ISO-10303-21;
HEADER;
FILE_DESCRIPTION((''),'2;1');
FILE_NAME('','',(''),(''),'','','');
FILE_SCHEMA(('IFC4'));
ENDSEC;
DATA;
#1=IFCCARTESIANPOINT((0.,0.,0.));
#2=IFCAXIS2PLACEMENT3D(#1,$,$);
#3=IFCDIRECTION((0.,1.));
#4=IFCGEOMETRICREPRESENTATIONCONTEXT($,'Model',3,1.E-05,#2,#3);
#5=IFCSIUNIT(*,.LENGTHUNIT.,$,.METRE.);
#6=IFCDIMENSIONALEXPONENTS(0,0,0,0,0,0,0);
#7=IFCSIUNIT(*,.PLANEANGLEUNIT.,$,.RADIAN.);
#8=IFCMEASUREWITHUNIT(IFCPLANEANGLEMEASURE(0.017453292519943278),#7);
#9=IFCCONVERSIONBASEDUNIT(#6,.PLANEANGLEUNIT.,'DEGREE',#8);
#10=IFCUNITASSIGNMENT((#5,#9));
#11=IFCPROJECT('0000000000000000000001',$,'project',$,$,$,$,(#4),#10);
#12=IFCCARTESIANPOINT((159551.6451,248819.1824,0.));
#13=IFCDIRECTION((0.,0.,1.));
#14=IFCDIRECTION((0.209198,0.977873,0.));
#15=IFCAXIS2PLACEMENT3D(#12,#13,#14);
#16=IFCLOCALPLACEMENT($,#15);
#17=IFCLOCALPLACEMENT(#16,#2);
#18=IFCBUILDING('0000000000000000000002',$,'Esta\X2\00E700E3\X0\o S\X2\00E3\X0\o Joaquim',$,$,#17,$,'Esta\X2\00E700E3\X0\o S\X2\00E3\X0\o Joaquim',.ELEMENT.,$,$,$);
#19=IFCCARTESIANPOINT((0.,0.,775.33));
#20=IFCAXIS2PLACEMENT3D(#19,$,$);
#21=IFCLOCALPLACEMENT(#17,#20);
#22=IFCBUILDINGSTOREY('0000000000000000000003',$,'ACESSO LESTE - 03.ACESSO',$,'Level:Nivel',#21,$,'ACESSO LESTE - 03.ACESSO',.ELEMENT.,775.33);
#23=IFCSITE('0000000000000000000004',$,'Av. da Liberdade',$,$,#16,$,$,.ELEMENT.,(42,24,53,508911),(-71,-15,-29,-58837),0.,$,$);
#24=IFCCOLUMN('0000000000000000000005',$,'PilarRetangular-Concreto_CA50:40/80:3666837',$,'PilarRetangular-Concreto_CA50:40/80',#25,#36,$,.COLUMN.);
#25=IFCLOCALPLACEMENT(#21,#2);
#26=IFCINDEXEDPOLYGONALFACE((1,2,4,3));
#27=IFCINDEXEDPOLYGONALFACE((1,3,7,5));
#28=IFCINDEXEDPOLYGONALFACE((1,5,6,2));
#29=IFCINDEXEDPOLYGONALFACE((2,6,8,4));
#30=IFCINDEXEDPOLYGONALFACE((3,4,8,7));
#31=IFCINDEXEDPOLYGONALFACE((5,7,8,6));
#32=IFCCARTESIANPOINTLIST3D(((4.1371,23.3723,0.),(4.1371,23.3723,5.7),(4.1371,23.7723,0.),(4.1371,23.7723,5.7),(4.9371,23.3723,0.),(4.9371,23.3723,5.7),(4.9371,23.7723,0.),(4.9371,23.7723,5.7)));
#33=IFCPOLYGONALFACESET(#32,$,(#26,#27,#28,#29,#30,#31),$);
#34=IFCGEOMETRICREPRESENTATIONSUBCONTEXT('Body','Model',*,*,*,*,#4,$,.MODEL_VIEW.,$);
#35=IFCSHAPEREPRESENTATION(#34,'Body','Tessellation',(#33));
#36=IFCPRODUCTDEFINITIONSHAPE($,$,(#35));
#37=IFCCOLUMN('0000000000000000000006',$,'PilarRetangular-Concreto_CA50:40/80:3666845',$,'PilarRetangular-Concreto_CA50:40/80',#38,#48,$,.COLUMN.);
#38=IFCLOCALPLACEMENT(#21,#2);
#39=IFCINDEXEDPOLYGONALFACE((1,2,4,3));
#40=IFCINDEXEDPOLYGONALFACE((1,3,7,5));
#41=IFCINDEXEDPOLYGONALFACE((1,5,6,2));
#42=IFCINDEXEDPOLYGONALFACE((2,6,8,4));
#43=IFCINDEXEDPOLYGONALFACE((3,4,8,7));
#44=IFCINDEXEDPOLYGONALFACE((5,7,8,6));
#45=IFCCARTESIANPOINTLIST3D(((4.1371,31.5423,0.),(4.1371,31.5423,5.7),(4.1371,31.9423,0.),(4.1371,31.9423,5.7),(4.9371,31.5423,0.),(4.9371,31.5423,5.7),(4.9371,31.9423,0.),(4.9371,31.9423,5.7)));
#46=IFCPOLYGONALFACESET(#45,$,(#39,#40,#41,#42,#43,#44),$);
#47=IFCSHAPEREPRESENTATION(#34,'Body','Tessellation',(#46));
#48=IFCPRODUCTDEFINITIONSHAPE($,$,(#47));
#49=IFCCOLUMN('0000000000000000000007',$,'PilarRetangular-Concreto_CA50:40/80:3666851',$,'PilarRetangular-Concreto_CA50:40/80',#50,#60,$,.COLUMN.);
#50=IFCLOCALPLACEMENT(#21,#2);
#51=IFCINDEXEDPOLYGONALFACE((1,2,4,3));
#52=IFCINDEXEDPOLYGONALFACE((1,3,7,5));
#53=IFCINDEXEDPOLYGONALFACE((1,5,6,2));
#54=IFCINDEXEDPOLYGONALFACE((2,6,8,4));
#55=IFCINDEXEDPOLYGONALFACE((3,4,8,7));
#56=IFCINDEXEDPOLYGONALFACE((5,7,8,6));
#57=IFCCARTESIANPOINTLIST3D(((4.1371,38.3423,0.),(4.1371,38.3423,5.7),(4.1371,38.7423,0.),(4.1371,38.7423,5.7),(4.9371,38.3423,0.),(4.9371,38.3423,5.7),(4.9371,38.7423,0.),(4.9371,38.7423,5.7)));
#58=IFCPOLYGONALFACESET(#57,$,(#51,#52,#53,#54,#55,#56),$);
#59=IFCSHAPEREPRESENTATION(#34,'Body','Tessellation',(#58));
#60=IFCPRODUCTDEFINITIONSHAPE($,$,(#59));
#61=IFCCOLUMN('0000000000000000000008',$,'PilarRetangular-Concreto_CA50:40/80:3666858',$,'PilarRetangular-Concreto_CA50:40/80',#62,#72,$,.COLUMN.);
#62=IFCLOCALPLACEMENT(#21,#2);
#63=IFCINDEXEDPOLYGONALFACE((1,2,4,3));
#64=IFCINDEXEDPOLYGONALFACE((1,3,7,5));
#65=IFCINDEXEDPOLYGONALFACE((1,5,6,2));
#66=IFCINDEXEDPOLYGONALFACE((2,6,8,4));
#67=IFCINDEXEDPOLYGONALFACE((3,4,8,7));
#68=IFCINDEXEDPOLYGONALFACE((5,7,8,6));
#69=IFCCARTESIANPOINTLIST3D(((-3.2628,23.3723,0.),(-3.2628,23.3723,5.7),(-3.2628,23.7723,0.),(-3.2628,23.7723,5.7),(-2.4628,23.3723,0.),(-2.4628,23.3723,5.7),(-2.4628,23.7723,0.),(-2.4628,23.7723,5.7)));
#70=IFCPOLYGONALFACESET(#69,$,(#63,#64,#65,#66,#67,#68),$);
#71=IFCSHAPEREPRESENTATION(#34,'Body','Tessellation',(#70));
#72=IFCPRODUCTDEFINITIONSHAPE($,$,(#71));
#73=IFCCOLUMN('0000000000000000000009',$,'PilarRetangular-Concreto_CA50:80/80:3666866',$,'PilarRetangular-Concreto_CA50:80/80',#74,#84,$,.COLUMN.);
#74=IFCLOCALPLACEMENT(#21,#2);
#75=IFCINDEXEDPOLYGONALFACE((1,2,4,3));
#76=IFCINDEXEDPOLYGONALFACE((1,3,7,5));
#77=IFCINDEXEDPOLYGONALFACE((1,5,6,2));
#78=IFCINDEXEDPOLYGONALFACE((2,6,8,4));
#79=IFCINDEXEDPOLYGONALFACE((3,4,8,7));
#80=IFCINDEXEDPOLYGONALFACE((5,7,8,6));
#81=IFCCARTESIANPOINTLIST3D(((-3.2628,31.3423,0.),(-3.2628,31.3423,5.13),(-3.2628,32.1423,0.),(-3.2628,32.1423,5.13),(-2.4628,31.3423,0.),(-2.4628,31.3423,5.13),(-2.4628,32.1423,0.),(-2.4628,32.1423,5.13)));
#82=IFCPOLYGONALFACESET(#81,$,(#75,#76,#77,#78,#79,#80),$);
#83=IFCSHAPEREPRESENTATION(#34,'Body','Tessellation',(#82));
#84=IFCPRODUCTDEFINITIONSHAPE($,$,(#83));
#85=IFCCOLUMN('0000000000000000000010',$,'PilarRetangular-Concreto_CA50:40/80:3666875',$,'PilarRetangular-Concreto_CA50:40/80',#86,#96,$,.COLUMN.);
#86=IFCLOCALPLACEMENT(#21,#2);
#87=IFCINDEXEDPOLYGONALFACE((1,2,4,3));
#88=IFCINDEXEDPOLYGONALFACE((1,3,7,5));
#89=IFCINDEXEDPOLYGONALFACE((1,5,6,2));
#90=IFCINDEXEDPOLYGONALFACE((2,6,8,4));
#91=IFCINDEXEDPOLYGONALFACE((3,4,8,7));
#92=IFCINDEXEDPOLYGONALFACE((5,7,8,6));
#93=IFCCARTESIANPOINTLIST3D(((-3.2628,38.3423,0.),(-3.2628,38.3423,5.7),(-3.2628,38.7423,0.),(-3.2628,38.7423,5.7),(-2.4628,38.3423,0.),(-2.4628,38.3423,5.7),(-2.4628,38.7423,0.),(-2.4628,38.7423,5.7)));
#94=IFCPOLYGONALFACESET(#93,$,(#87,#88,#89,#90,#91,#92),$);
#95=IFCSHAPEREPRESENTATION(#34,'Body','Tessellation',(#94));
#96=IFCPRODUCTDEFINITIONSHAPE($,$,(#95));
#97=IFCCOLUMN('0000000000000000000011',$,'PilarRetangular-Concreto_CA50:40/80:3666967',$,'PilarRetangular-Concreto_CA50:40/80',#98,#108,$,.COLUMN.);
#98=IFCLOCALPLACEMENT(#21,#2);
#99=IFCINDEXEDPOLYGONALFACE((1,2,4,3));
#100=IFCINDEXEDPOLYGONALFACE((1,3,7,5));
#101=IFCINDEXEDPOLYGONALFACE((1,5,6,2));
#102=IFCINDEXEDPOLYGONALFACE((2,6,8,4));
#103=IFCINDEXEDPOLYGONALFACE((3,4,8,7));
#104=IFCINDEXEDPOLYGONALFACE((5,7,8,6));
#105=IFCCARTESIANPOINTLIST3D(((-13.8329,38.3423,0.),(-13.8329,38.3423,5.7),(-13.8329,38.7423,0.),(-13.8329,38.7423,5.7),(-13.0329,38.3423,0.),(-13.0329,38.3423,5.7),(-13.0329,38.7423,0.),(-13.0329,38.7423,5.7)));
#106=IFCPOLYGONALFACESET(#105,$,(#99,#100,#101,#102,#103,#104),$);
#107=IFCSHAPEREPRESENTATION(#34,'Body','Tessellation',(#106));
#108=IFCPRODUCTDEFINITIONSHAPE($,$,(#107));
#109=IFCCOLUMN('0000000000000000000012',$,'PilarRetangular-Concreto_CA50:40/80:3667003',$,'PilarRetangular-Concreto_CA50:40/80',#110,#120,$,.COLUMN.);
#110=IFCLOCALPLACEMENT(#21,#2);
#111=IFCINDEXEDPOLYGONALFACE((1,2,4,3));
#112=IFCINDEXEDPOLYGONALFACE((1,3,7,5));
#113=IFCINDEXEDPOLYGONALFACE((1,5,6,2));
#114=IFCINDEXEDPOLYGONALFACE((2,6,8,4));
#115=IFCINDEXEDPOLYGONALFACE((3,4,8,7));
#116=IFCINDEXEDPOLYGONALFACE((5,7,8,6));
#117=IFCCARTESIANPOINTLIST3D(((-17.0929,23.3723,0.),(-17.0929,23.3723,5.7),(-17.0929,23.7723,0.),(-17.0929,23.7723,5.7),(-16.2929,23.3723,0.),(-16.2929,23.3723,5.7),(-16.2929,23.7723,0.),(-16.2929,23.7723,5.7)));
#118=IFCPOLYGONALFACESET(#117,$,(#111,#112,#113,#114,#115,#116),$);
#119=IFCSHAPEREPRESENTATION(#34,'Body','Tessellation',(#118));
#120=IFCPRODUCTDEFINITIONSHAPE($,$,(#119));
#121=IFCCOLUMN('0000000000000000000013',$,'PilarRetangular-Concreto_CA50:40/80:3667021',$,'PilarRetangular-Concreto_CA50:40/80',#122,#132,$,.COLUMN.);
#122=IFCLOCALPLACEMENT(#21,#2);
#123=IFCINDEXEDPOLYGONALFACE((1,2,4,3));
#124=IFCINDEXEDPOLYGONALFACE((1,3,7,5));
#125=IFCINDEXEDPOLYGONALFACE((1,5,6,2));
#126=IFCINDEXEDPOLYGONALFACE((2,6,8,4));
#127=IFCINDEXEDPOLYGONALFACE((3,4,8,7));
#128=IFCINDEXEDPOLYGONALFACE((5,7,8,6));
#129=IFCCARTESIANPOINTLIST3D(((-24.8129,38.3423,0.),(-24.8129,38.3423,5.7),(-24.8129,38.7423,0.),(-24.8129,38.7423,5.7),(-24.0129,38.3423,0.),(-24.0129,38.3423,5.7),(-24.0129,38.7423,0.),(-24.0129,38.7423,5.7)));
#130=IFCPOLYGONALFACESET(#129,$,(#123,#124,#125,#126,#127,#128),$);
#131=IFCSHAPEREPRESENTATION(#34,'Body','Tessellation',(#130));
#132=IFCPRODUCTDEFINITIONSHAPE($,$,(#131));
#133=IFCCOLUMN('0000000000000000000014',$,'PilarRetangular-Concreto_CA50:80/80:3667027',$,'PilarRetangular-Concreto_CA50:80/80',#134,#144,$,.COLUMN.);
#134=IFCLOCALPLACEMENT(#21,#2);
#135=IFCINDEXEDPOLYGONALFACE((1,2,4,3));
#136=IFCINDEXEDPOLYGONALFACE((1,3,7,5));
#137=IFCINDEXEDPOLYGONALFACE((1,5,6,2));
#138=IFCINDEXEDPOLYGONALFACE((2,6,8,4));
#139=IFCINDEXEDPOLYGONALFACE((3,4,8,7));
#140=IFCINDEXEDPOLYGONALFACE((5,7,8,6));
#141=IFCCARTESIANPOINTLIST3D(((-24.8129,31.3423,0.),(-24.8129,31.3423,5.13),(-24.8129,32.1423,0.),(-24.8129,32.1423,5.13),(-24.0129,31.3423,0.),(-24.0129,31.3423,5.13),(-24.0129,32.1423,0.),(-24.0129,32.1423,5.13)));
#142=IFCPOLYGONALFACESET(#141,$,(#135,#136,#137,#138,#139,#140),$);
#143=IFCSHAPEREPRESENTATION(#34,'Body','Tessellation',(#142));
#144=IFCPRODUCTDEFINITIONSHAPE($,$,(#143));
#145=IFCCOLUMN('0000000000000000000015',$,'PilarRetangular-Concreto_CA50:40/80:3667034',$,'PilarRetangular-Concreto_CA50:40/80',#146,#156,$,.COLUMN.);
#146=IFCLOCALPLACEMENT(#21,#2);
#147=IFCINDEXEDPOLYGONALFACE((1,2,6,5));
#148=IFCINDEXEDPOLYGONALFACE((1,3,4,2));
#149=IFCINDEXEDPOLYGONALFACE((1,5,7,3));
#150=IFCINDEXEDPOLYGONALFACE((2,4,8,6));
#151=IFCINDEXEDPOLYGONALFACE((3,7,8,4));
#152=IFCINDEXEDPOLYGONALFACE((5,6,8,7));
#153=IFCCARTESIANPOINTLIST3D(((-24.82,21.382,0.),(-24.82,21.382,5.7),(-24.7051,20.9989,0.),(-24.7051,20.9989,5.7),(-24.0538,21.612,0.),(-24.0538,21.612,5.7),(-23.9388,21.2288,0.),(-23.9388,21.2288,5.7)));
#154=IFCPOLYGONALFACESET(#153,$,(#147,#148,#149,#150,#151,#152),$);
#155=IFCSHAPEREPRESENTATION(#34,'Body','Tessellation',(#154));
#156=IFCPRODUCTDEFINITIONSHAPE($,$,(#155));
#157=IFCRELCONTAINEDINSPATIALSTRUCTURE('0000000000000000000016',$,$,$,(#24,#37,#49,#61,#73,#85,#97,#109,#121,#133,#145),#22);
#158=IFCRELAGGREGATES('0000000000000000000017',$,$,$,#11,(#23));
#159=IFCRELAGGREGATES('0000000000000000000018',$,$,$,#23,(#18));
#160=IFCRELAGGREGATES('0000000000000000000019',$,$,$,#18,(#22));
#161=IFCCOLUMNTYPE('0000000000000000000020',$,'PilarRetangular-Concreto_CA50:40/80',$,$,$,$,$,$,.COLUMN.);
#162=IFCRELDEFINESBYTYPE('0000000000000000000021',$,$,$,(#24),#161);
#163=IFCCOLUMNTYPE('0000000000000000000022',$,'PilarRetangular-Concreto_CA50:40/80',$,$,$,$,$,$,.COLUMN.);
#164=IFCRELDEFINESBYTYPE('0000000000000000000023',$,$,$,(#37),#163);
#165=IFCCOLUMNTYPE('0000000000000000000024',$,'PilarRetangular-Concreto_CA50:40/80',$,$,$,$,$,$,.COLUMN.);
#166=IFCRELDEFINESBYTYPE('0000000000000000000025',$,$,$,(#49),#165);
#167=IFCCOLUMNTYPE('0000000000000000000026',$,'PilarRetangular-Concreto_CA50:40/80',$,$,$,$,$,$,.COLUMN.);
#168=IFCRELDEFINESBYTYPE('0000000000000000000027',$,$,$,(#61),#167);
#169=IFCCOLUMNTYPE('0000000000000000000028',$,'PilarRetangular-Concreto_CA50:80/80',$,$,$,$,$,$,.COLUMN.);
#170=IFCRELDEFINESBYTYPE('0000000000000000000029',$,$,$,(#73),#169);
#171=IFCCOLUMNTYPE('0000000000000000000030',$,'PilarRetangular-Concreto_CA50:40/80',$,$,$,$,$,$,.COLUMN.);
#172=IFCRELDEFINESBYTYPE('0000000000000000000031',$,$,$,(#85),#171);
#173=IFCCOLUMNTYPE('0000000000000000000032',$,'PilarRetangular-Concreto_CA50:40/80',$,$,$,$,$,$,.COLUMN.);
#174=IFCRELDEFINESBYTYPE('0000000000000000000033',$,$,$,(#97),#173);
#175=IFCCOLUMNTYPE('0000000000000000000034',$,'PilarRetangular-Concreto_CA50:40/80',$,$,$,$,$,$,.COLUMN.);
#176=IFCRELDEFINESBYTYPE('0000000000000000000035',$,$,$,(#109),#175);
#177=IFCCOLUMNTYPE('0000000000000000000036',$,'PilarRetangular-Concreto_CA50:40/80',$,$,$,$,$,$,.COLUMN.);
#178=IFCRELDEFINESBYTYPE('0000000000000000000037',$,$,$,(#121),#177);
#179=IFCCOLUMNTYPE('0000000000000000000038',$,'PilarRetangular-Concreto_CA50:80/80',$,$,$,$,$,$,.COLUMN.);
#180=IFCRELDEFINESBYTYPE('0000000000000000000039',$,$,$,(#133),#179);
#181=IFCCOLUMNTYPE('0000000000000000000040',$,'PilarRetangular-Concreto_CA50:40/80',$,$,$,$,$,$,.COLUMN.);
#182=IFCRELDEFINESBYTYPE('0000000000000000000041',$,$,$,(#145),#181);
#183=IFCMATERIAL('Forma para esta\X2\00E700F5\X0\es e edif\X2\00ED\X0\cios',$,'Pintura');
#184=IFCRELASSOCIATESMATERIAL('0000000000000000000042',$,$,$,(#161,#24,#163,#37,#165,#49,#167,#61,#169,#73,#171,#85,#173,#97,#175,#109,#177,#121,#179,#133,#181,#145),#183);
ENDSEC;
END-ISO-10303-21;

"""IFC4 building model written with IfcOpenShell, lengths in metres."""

from ifc_helpers import new_model, entity, si_unit, converted_unit, direction, frame, origin, place, context, subcontext, project, spatial, indexed_curve, outline, extrude, source, transform, mapped, material, type_object, type_shapes, element, save


model = new_model("IFC4")

# Units and contexts
model_context = context("Model", 3, precision=1e-05, world=origin(), true_north=direction((0.0, 1.0)))
body_context = subcontext(model_context, "Body", "Model", "MODEL_VIEW")
ifc_project = project(units=[si_unit("LENGTHUNIT", "METRE"), converted_unit("PLANEANGLEUNIT", "DEGREE", entity("IfcPlaneAngleMeasure", 0.017453292519943278), si_unit("PLANEANGLEUNIT", "RADIAN"), dimensions=[0, 0, 0, 0, 0, 0, 0])], contexts=[model_context])

# Site, building, storey
site_placement = place(None, frame((159551.6451, 248819.1824, 0.0), z_axis=(0.0, 0.0, 1.0), x_axis=(0.209198, 0.977873, 0.0)))
site = spatial("IfcSite", under=ifc_project, at=site_placement, Name="Av. da Liberdade", CompositionType="ELEMENT", RefLatitude=(42, 24, 53, 508911), RefLongitude=(-71, -15, -29, -58837), RefElevation=0.0)
building_placement = place(site_placement, origin())
building = spatial("IfcBuilding", under=site, at=building_placement, Name="Estação São Joaquim", LongName="Estação São Joaquim", CompositionType="ELEMENT")
storey_placement = place(building_placement, frame((0.0, 0.0, 775.33)))
storey = spatial("IfcBuildingStorey", under=building, at=storey_placement, Name="ACESSO LESTE - 03.ACESSO", ObjectType="Level:Nivel", LongName="ACESSO LESTE - 03.ACESSO", CompositionType="ELEMENT", Elevation=775.33)

# Columns
ifc_material_1 = material(Name="Forma para estações e edifícios", Category="Pintura")
column_type_1 = type_object("IfcColumnType", Name="PilarRetangular-Concreto_CA50:40/80", PredefinedType="COLUMN", material=ifc_material_1)
shared_shape_1 = source(origin(), body_context, "Body", "SweptSolid", [
    extrude(outline(indexed_curve([(-0.2, -0.4), (0.2, -0.4), (0.2, 0.4), (-0.2, 0.4), (-0.2, -0.4)], self_intersect=False)), frame((4.5371, 23.5723, 775.33), z_axis=(0.0, 0.0, 1.0), x_axis=(0.0, -1.0, 0.0)), (0.0, 0.0, 1.0), 5.7),
])
type_shapes(column_type_1, [shared_shape_1])
column_1_placement = place(storey_placement, frame((0.0, 0.0, -775.33)))
element("IfcColumn", 1, at=column_1_placement, inside=storey, type_object=column_type_1, material=ifc_material_1, Name="PilarRetangular-Concreto_CA50:40/80:3666837", ObjectType="PilarRetangular-Concreto_CA50:40/80", PredefinedType="COLUMN", context=body_context, shape_type="MappedRepresentation", body=[
    mapped(shared_shape_1, transform((0.0, 0.0, 0.0), scale=1.0)),
])
column_type_2 = type_object("IfcColumnType", Name="PilarRetangular-Concreto_CA50:40/80", PredefinedType="COLUMN", material=ifc_material_1)
shared_shape_2 = source(origin(), body_context, "Body", "SweptSolid", [
    extrude(outline(indexed_curve([(-0.2, -0.4), (0.2, -0.4), (0.2, 0.4), (-0.2, 0.4), (-0.2, -0.4)], self_intersect=False)), frame((4.5371, 31.7423, 775.33), z_axis=(0.0, 0.0, 1.0), x_axis=(0.0, -1.0, 0.0)), (0.0, 0.0, 1.0), 5.7),
])
type_shapes(column_type_2, [shared_shape_2])
column_2_placement = place(storey_placement, frame((0.0, 0.0, -775.33)))
element("IfcColumn", 2, at=column_2_placement, inside=storey, type_object=column_type_2, material=ifc_material_1, Name="PilarRetangular-Concreto_CA50:40/80:3666845", ObjectType="PilarRetangular-Concreto_CA50:40/80", PredefinedType="COLUMN", context=body_context, shape_type="MappedRepresentation", body=[
    mapped(shared_shape_2, transform((0.0, 0.0, 0.0), scale=1.0)),
])
column_type_3 = type_object("IfcColumnType", Name="PilarRetangular-Concreto_CA50:40/80", PredefinedType="COLUMN", material=ifc_material_1)
shared_shape_3 = source(origin(), body_context, "Body", "SweptSolid", [
    extrude(outline(indexed_curve([(-0.2, -0.4), (0.2, -0.4), (0.2, 0.4), (-0.2, 0.4), (-0.2, -0.4)], self_intersect=False)), frame((4.5371, 38.5423, 775.33), z_axis=(0.0, 0.0, 1.0), x_axis=(0.0, 1.0, 0.0)), (0.0, 0.0, 1.0), 5.7),
])
type_shapes(column_type_3, [shared_shape_3])
column_3_placement = place(storey_placement, frame((0.0, 0.0, -775.33)))
element("IfcColumn", 3, at=column_3_placement, inside=storey, type_object=column_type_3, material=ifc_material_1, Name="PilarRetangular-Concreto_CA50:40/80:3666851", ObjectType="PilarRetangular-Concreto_CA50:40/80", PredefinedType="COLUMN", context=body_context, shape_type="MappedRepresentation", body=[
    mapped(shared_shape_3, transform((0.0, 0.0, 0.0), scale=1.0)),
])
column_type_4 = type_object("IfcColumnType", Name="PilarRetangular-Concreto_CA50:40/80", PredefinedType="COLUMN", material=ifc_material_1)
shared_shape_4 = source(origin(), body_context, "Body", "SweptSolid", [
    extrude(outline(indexed_curve([(-0.2, -0.4), (0.2, -0.4), (0.2, 0.4), (-0.2, 0.4), (-0.2, -0.4)], self_intersect=False)), frame((-2.8628, 23.5723, 775.33), z_axis=(0.0, 0.0, 1.0), x_axis=(0.0, -1.0, 0.0)), (0.0, 0.0, 1.0), 5.7),
])
type_shapes(column_type_4, [shared_shape_4])
column_4_placement = place(storey_placement, frame((0.0, 0.0, -775.33)))
element("IfcColumn", 4, at=column_4_placement, inside=storey, type_object=column_type_4, material=ifc_material_1, Name="PilarRetangular-Concreto_CA50:40/80:3666858", ObjectType="PilarRetangular-Concreto_CA50:40/80", PredefinedType="COLUMN", context=body_context, shape_type="MappedRepresentation", body=[
    mapped(shared_shape_4, transform((0.0, 0.0, 0.0), scale=1.0)),
])
column_type_5 = type_object("IfcColumnType", Name="PilarRetangular-Concreto_CA50:80/80", PredefinedType="COLUMN", material=ifc_material_1)
shared_shape_5 = source(origin(), body_context, "Body", "SweptSolid", [
    extrude(outline(indexed_curve([(-0.4, -0.4), (0.4, -0.4), (0.4, 0.4), (-0.4, 0.4), (-0.4, -0.4)], self_intersect=False)), frame((-2.8628, 31.7423, 775.33), z_axis=(0.0, 0.0, 1.0), x_axis=(-1.0, 0.0, 0.0)), (0.0, 0.0, 1.0), 5.13),
])
type_shapes(column_type_5, [shared_shape_5])
column_5_placement = place(storey_placement, frame((0.0, 0.0, -775.33)))
element("IfcColumn", 5, at=column_5_placement, inside=storey, type_object=column_type_5, material=ifc_material_1, Name="PilarRetangular-Concreto_CA50:80/80:3666866", ObjectType="PilarRetangular-Concreto_CA50:80/80", PredefinedType="COLUMN", context=body_context, shape_type="MappedRepresentation", body=[
    mapped(shared_shape_5, transform((0.0, 0.0, 0.0), scale=1.0)),
])
column_type_6 = type_object("IfcColumnType", Name="PilarRetangular-Concreto_CA50:40/80", PredefinedType="COLUMN", material=ifc_material_1)
shared_shape_6 = source(origin(), body_context, "Body", "SweptSolid", [
    extrude(outline(indexed_curve([(-0.2, -0.4), (0.2, -0.4), (0.2, 0.4), (-0.2, 0.4), (-0.2, -0.4)], self_intersect=False)), frame((-2.8628, 38.5423, 775.33), z_axis=(0.0, 0.0, 1.0), x_axis=(0.0, 1.0, 0.0)), (0.0, 0.0, 1.0), 5.7),
])
type_shapes(column_type_6, [shared_shape_6])
column_6_placement = place(storey_placement, frame((0.0, 0.0, -775.33)))
element("IfcColumn", 6, at=column_6_placement, inside=storey, type_object=column_type_6, material=ifc_material_1, Name="PilarRetangular-Concreto_CA50:40/80:3666875", ObjectType="PilarRetangular-Concreto_CA50:40/80", PredefinedType="COLUMN", context=body_context, shape_type="MappedRepresentation", body=[
    mapped(shared_shape_6, transform((0.0, 0.0, 0.0), scale=1.0)),
])
column_type_7 = type_object("IfcColumnType", Name="PilarRetangular-Concreto_CA50:40/80", PredefinedType="COLUMN", material=ifc_material_1)
shared_shape_7 = source(origin(), body_context, "Body", "SweptSolid", [
    extrude(outline(indexed_curve([(-0.2, -0.4), (0.2, -0.4), (0.2, 0.4), (-0.2, 0.4), (-0.2, -0.4)], self_intersect=False)), frame((-13.4329, 38.5423, 775.33), z_axis=(0.0, 0.0, 1.0), x_axis=(0.0, 1.0, 0.0)), (0.0, 0.0, 1.0), 5.7),
])
type_shapes(column_type_7, [shared_shape_7])
column_7_placement = place(storey_placement, frame((0.0, 0.0, -775.33)))
element("IfcColumn", 7, at=column_7_placement, inside=storey, type_object=column_type_7, material=ifc_material_1, Name="PilarRetangular-Concreto_CA50:40/80:3666967", ObjectType="PilarRetangular-Concreto_CA50:40/80", PredefinedType="COLUMN", context=body_context, shape_type="MappedRepresentation", body=[
    mapped(shared_shape_7, transform((0.0, 0.0, 0.0), scale=1.0)),
])
column_type_8 = type_object("IfcColumnType", Name="PilarRetangular-Concreto_CA50:40/80", PredefinedType="COLUMN", material=ifc_material_1)
shared_shape_8 = source(origin(), body_context, "Body", "SweptSolid", [
    extrude(outline(indexed_curve([(-0.2, -0.4), (0.2, -0.4), (0.2, 0.4), (-0.2, 0.4), (-0.2, -0.4)], self_intersect=False)), frame((-16.6929, 23.5723, 775.33), z_axis=(0.0, 0.0, 1.0), x_axis=(0.0, -1.0, 0.0)), (0.0, 0.0, 1.0), 5.7),
])
type_shapes(column_type_8, [shared_shape_8])
column_8_placement = place(storey_placement, frame((0.0, 0.0, -775.33)))
element("IfcColumn", 8, at=column_8_placement, inside=storey, type_object=column_type_8, material=ifc_material_1, Name="PilarRetangular-Concreto_CA50:40/80:3667003", ObjectType="PilarRetangular-Concreto_CA50:40/80", PredefinedType="COLUMN", context=body_context, shape_type="MappedRepresentation", body=[
    mapped(shared_shape_8, transform((0.0, 0.0, 0.0), scale=1.0)),
])
column_type_9 = type_object("IfcColumnType", Name="PilarRetangular-Concreto_CA50:40/80", PredefinedType="COLUMN", material=ifc_material_1)
shared_shape_9 = source(origin(), body_context, "Body", "SweptSolid", [
    extrude(outline(indexed_curve([(-0.2, -0.4), (0.2, -0.4), (0.2, 0.4), (-0.2, 0.4), (-0.2, -0.4)], self_intersect=False)), frame((-24.4129, 38.5423, 775.33), z_axis=(0.0, 0.0, 1.0), x_axis=(0.0, -1.0, 0.0)), (0.0, 0.0, 1.0), 5.7),
])
type_shapes(column_type_9, [shared_shape_9])
column_9_placement = place(storey_placement, frame((0.0, 0.0, -775.33)))
element("IfcColumn", 9, at=column_9_placement, inside=storey, type_object=column_type_9, material=ifc_material_1, Name="PilarRetangular-Concreto_CA50:40/80:3667021", ObjectType="PilarRetangular-Concreto_CA50:40/80", PredefinedType="COLUMN", context=body_context, shape_type="MappedRepresentation", body=[
    mapped(shared_shape_9, transform((0.0, 0.0, 0.0), scale=1.0)),
])
column_type_10 = type_object("IfcColumnType", Name="PilarRetangular-Concreto_CA50:80/80", PredefinedType="COLUMN", material=ifc_material_1)
shared_shape_10 = source(origin(), body_context, "Body", "SweptSolid", [
    extrude(outline(indexed_curve([(-0.4, -0.4), (0.4, -0.4), (0.4, 0.4), (-0.4, 0.4), (-0.4, -0.4)], self_intersect=False)), frame((-24.4129, 31.7423, 775.33), z_axis=(0.0, 0.0, 1.0), x_axis=(-1.0, 0.0, 0.0)), (0.0, 0.0, 1.0), 5.13),
])
type_shapes(column_type_10, [shared_shape_10])
column_10_placement = place(storey_placement, frame((0.0, 0.0, -775.33)))
element("IfcColumn", 10, at=column_10_placement, inside=storey, type_object=column_type_10, material=ifc_material_1, Name="PilarRetangular-Concreto_CA50:80/80:3667027", ObjectType="PilarRetangular-Concreto_CA50:80/80", PredefinedType="COLUMN", context=body_context, shape_type="MappedRepresentation", body=[
    mapped(shared_shape_10, transform((0.0, 0.0, 0.0), scale=1.0)),
])
column_type_11 = type_object("IfcColumnType", Name="PilarRetangular-Concreto_CA50:40/80", PredefinedType="COLUMN", material=ifc_material_1)
shared_shape_11 = source(origin(), body_context, "Body", "SweptSolid", [
    extrude(outline(indexed_curve([(-0.2, -0.4), (0.2, -0.4), (0.2, 0.4), (-0.2, 0.4), (-0.2, -0.4)], self_intersect=False)), frame((-24.3794, 21.3054, 775.33), z_axis=(0.0, 0.0, 1.0), x_axis=(0.287438, -0.957799, 0.0)), (0.0, 0.0, 1.0), 5.7),
])
type_shapes(column_type_11, [shared_shape_11])
column_11_placement = place(storey_placement, frame((0.0, 0.0, -775.33)))
element("IfcColumn", 11, at=column_11_placement, inside=storey, type_object=column_type_11, material=ifc_material_1, Name="PilarRetangular-Concreto_CA50:40/80:3667034", ObjectType="PilarRetangular-Concreto_CA50:40/80", PredefinedType="COLUMN", context=body_context, shape_type="MappedRepresentation", body=[
    mapped(shared_shape_11, transform((0.0, 0.0, 0.0), scale=1.0)),
])

save(model, "model.ifc")
